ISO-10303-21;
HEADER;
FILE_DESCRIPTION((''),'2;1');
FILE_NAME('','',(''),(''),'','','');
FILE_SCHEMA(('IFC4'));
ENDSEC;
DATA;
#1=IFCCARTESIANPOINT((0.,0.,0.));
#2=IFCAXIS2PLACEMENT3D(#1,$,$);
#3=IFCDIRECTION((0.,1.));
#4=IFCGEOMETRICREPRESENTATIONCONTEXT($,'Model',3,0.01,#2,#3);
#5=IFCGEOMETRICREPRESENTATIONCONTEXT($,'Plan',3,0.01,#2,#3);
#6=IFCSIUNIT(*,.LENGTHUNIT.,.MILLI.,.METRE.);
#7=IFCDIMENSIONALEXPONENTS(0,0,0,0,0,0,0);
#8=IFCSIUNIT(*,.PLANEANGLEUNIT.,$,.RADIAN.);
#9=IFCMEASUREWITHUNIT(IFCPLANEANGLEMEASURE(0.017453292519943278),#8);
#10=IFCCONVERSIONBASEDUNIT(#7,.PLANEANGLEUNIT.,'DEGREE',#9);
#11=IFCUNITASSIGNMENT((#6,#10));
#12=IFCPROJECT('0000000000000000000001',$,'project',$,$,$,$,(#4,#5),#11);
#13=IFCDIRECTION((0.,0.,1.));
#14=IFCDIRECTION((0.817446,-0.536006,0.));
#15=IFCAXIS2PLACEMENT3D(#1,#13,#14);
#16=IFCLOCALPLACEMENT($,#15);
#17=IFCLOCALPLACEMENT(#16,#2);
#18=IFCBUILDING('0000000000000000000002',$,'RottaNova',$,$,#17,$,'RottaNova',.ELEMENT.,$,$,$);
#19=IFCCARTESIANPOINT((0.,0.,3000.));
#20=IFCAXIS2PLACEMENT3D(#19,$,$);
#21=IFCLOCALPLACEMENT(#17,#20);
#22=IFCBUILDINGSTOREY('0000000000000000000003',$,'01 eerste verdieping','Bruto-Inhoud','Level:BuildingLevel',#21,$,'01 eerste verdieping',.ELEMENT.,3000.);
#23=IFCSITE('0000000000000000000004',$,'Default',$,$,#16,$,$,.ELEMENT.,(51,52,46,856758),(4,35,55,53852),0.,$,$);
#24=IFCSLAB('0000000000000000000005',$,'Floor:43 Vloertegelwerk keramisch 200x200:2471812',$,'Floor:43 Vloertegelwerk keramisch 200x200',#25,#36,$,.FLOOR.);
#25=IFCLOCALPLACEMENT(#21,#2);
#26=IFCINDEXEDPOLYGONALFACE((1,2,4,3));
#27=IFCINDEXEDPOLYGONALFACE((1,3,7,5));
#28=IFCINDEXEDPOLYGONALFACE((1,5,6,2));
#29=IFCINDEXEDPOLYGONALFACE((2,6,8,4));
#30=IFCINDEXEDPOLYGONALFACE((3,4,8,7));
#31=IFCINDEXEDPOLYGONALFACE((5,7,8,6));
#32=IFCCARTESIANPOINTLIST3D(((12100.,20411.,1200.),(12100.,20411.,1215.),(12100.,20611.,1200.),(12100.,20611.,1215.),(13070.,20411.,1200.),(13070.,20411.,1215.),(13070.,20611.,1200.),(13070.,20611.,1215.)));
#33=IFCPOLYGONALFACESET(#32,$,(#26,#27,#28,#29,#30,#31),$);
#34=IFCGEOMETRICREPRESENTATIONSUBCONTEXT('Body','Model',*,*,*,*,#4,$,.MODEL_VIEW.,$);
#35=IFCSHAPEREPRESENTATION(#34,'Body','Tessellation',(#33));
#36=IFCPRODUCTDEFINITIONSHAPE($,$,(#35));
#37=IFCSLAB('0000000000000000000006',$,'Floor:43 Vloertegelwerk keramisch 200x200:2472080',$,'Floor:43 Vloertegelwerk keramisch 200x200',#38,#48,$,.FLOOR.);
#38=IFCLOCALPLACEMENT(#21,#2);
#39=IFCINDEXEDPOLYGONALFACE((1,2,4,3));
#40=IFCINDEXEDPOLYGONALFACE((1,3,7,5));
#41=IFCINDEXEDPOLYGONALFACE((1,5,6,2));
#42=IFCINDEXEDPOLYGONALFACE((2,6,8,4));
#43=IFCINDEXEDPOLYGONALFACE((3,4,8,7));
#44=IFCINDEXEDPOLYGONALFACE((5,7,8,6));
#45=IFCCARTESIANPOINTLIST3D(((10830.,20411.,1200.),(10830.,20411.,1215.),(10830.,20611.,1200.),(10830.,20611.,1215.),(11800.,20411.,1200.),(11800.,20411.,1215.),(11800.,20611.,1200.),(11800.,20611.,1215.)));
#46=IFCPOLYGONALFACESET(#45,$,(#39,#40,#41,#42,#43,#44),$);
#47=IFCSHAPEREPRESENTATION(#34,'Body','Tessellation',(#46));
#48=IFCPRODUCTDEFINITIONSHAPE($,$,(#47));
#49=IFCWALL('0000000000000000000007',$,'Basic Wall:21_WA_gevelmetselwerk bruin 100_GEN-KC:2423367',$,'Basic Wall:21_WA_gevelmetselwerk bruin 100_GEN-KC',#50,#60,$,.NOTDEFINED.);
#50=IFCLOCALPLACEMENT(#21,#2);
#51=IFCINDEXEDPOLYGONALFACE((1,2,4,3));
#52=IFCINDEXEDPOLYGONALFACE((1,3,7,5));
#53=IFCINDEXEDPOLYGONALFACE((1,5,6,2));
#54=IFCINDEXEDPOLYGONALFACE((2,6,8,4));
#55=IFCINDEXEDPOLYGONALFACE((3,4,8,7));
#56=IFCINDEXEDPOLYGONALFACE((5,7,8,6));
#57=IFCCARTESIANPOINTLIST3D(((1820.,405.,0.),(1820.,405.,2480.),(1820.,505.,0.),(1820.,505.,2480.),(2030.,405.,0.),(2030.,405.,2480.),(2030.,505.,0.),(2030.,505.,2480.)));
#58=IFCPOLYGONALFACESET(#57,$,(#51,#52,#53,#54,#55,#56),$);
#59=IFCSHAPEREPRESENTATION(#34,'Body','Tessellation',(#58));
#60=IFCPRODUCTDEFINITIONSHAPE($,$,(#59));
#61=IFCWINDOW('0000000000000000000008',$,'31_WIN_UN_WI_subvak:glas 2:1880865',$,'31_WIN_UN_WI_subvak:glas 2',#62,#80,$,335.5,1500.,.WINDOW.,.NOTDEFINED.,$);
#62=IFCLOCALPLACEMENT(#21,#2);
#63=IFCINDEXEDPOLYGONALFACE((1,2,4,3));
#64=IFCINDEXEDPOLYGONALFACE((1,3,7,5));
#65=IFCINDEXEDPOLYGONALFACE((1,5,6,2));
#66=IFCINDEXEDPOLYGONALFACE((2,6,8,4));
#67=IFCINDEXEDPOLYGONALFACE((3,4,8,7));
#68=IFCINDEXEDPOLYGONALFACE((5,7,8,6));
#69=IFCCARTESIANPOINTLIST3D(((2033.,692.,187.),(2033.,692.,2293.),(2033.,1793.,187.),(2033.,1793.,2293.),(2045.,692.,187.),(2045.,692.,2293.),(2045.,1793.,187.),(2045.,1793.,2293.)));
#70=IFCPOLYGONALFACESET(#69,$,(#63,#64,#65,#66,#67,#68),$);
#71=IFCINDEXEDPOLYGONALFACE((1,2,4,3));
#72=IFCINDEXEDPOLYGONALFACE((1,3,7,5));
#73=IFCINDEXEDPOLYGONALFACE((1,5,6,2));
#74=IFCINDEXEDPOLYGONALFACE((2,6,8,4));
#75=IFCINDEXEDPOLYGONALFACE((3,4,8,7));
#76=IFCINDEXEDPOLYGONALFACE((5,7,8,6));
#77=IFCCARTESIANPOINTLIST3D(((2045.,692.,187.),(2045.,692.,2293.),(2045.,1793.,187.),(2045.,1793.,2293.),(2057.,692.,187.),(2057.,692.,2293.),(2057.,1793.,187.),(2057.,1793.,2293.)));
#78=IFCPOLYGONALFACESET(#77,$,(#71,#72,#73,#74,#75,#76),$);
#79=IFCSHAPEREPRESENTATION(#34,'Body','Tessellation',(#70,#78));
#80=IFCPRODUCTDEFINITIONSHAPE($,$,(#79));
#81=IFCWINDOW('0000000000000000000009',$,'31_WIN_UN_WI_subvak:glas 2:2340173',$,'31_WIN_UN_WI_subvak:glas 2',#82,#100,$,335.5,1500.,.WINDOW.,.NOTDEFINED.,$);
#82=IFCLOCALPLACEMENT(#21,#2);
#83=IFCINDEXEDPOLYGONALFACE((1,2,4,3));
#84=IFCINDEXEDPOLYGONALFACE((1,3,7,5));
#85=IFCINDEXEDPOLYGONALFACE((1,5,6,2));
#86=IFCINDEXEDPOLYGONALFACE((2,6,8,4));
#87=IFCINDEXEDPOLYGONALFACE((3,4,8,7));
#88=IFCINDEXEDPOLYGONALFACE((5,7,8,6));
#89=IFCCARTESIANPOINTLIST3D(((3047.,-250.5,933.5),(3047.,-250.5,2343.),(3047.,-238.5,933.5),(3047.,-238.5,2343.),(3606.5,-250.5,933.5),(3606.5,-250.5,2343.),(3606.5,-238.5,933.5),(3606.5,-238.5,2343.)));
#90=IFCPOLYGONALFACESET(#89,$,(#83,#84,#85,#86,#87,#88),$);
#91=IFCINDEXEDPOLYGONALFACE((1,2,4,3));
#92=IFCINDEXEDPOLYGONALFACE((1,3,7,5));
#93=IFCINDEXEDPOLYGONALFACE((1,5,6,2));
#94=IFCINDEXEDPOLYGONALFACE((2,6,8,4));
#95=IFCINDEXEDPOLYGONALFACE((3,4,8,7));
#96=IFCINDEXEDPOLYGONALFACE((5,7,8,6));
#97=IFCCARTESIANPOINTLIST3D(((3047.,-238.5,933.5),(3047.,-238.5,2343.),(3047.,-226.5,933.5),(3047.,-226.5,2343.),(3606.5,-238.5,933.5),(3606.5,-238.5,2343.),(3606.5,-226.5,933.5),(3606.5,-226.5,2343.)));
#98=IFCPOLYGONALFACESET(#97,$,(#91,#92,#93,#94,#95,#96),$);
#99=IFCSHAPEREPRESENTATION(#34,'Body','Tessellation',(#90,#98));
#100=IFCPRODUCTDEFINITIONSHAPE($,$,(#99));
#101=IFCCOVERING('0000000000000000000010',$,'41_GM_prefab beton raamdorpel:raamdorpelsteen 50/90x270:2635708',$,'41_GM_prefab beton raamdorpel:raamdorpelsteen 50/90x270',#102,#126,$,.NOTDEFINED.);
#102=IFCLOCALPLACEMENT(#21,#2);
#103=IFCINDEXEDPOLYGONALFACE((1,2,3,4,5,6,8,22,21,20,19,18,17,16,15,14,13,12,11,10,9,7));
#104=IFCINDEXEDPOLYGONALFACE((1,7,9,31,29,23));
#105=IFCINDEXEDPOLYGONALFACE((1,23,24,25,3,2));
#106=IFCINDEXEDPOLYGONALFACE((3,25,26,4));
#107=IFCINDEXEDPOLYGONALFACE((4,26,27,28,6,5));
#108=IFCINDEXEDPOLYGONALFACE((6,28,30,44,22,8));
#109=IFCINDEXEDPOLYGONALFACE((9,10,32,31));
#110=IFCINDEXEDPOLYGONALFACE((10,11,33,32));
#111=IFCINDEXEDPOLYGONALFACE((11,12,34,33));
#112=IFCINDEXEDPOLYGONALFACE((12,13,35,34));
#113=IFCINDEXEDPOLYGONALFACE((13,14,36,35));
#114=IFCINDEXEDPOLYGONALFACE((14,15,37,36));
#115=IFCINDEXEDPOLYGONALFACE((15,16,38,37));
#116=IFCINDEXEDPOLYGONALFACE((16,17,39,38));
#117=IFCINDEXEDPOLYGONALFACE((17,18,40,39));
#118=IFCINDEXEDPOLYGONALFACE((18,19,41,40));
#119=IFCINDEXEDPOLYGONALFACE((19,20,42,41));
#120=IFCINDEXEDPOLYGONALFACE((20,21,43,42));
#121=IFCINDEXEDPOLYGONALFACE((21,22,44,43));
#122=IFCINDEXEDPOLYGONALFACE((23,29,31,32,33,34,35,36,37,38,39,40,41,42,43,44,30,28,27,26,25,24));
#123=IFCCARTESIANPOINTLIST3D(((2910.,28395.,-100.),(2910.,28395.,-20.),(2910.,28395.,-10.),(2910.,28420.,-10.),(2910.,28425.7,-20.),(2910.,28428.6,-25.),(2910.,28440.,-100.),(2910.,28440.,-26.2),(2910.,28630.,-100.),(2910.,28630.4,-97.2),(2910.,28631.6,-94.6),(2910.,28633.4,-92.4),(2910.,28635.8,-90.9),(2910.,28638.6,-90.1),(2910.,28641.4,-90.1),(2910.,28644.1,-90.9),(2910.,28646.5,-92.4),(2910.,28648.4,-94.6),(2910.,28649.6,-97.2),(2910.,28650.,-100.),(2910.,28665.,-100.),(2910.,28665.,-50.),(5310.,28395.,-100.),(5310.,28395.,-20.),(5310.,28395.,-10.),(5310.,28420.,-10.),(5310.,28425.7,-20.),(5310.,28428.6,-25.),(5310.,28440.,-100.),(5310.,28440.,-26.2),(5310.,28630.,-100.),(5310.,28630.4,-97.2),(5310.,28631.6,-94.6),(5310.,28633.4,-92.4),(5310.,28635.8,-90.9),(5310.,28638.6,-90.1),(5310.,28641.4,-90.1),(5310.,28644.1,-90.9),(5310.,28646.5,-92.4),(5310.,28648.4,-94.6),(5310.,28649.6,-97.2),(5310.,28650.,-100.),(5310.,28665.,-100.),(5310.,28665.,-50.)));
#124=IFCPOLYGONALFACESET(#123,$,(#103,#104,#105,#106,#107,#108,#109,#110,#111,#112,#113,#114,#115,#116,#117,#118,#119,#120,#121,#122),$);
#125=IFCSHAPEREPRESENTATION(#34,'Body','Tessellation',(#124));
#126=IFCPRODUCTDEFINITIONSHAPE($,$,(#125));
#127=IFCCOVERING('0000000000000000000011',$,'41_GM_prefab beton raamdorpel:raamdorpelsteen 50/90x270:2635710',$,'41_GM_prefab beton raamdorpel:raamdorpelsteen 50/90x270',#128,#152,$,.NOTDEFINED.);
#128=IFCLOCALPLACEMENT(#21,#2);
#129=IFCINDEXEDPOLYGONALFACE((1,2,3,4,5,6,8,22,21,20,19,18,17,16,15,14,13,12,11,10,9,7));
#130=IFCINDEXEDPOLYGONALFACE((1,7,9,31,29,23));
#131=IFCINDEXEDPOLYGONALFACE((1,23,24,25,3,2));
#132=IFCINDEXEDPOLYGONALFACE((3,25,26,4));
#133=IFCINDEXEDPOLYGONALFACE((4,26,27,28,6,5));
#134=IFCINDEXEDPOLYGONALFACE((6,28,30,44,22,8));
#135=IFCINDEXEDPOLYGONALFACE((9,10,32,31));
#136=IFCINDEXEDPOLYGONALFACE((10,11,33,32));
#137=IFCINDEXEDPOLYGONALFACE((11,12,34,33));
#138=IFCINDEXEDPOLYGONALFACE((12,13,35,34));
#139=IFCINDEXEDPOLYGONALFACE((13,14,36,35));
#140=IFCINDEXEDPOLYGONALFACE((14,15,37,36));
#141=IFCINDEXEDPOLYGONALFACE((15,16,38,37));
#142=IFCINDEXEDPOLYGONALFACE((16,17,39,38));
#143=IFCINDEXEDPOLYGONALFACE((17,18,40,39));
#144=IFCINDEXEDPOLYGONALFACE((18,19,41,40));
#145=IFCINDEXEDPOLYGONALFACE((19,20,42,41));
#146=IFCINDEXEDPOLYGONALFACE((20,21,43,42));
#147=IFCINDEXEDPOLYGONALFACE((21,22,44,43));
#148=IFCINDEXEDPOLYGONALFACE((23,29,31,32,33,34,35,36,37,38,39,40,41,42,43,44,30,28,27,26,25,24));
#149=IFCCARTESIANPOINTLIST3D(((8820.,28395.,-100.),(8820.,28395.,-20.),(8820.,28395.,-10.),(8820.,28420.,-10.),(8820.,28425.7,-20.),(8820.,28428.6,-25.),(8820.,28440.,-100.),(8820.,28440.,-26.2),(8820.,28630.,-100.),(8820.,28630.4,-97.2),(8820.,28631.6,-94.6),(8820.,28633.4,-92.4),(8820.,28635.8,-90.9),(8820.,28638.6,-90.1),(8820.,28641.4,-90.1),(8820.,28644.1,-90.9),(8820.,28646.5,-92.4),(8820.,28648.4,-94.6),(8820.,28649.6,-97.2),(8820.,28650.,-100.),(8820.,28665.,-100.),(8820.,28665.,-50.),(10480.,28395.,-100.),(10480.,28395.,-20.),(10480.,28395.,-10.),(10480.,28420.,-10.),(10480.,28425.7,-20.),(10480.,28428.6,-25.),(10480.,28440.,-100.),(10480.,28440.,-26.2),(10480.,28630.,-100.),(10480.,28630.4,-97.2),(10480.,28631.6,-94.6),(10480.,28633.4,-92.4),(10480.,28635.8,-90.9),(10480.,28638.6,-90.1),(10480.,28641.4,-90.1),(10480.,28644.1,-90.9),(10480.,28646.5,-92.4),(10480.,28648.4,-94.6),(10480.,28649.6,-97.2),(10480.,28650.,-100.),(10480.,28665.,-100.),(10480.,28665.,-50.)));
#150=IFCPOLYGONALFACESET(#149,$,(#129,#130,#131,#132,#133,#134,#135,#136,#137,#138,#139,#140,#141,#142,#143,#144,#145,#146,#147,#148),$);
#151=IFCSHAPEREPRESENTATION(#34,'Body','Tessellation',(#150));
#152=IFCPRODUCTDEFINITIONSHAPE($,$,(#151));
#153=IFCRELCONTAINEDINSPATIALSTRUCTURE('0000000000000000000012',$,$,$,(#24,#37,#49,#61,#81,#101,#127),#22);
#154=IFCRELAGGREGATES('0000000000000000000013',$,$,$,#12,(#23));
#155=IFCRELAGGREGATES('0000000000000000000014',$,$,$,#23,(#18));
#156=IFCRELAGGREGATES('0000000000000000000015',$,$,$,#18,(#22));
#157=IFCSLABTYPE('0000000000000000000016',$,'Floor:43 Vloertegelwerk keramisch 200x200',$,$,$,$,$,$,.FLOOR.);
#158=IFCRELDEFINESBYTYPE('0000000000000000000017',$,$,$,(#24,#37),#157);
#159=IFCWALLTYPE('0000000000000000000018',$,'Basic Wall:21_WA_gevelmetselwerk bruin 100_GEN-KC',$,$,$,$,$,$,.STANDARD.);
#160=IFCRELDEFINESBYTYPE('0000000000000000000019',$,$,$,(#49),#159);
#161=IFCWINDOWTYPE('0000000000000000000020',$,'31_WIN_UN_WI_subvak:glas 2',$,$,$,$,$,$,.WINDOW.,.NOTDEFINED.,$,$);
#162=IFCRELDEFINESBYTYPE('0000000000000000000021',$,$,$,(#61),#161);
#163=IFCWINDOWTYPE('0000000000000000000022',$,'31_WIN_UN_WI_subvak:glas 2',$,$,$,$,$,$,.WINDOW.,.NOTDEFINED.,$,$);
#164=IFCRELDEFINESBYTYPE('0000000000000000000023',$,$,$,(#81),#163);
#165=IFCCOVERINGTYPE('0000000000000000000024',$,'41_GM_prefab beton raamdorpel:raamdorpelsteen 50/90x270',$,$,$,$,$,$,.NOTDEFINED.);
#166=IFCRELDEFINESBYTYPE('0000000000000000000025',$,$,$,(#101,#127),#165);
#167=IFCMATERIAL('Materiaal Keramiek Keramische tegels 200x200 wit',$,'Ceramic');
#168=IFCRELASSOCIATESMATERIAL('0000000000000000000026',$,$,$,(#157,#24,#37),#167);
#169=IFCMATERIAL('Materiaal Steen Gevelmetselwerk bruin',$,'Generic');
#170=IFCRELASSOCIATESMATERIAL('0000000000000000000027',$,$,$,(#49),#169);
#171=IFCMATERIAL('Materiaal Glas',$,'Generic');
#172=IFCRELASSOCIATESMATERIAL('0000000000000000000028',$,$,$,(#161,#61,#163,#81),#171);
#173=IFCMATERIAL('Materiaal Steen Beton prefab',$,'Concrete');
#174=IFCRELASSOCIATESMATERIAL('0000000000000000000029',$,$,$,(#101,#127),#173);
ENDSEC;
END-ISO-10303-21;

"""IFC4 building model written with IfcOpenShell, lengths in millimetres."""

from ifc_helpers import new_model, entity, si_unit, converted_unit, direction, frame, origin, place, context, subcontext, project, spatial, line, arc, indexed_curve, outline, extrude, source, transform, mapped, material, type_object, type_shapes, element, save


model = new_model("IFC4")

# Units and contexts
model_context = context("Model", 3, precision=0.01, world=origin(), true_north=direction((0.0, 1.0)))
plan_context = context("Plan", 3, precision=0.01, world=origin(), true_north=direction((0.0, 1.0)))
body_context = subcontext(model_context, "Body", "Model", "MODEL_VIEW")
ifc_project = project(units=[si_unit("LENGTHUNIT", "METRE", prefix="MILLI"), converted_unit("PLANEANGLEUNIT", "DEGREE", entity("IfcPlaneAngleMeasure", 0.017453292519943278), si_unit("PLANEANGLEUNIT", "RADIAN"), dimensions=[0, 0, 0, 0, 0, 0, 0])], contexts=[model_context, plan_context])

# Site, building, storey
site_placement = place(None, frame((0.0, 0.0, 0.0), z_axis=(0.0, 0.0, 1.0), x_axis=(0.817446, -0.536006, 0.0)))
site = spatial("IfcSite", under=ifc_project, at=site_placement, Name="Default", CompositionType="ELEMENT", RefLatitude=(51, 52, 46, 856758), RefLongitude=(4, 35, 55, 53852), RefElevation=0.0)
building_placement = place(site_placement, origin())
building = spatial("IfcBuilding", under=site, at=building_placement, Name="RottaNova", LongName="RottaNova", CompositionType="ELEMENT")
storey_placement = place(building_placement, frame((0.0, 0.0, 3000.0)))
storey = spatial("IfcBuildingStorey", under=building, at=storey_placement, Name="01 eerste verdieping", Description="Bruto-Inhoud", ObjectType="Level:BuildingLevel", LongName="01 eerste verdieping", CompositionType="ELEMENT", Elevation=3000.0)

# Slabs
ifc_material_1 = material(Name="Materiaal Keramiek Keramische tegels 200x200 wit", Category="Ceramic")
slab_type = type_object("IfcSlabType", Name="Floor:43 Vloertegelwerk keramisch 200x200", PredefinedType="FLOOR", material=ifc_material_1)
slab_1_placement = place(storey_placement, origin())
element("IfcSlab", 1, at=slab_1_placement, inside=storey, type_object=slab_type, material=ifc_material_1, Name="Floor:43 Vloertegelwerk keramisch 200x200:2471812", ObjectType="Floor:43 Vloertegelwerk keramisch 200x200", PredefinedType="FLOOR", context=body_context, shape_type="SweptSolid", body=[
    extrude(outline(indexed_curve([(-100.0, -485.0), (100.0, -485.0), (100.0, 485.0), (-100.0, 485.0), (-100.0, -485.0)], self_intersect=False)), frame((12585.0, 20511.0, 1215.0), z_axis=(0.0, 0.0, -1.0), x_axis=(0.0, 1.0, 0.0)), (0.0, 0.0, 1.0), 15.0),
])
slab_2_placement = place(storey_placement, origin())
element("IfcSlab", 2, at=slab_2_placement, inside=storey, type_object=slab_type, material=ifc_material_1, Name="Floor:43 Vloertegelwerk keramisch 200x200:2472080", ObjectType="Floor:43 Vloertegelwerk keramisch 200x200", PredefinedType="FLOOR", context=body_context, shape_type="SweptSolid", body=[
    extrude(outline(indexed_curve([(-100.0, -485.0), (100.0, -485.0), (100.0, 485.0), (-100.0, 485.0), (-100.0, -485.0)], self_intersect=False)), frame((11315.0, 20511.0, 1215.0), z_axis=(0.0, 0.0, -1.0), x_axis=(0.0, 1.0, 0.0)), (0.0, 0.0, 1.0), 15.0),
])

# Wall
ifc_material_2 = material(Name="Materiaal Steen Gevelmetselwerk bruin", Category="Generic")
wall_type = type_object("IfcWallType", Name="Basic Wall:21_WA_gevelmetselwerk bruin 100_GEN-KC", PredefinedType="STANDARD")
wall_placement = place(storey_placement, frame((2030.0, 455.0, 0.0), z_axis=(0.0, 0.0, 1.0), x_axis=(-1.0, 0.0, 0.0)))
element("IfcWall", 3, at=wall_placement, inside=storey, type_object=wall_type, material=ifc_material_2, Name="Basic Wall:21_WA_gevelmetselwerk bruin 100_GEN-KC:2423367", ObjectType="Basic Wall:21_WA_gevelmetselwerk bruin 100_GEN-KC", PredefinedType="NOTDEFINED", context=body_context, shape_type="SweptSolid", body=[
    extrude(outline(indexed_curve([(210.0, 50.0), (0.0, 50.0), (0.0, -50.0), (210.0, -50.0), (210.0, 50.0)], self_intersect=False)), origin(), (0.0, 0.0, 1.0), 2480.0),
])

# Windows
ifc_material_3 = material(Name="Materiaal Glas", Category="Generic")
window_type_1 = type_object("IfcWindowType", Name="31_WIN_UN_WI_subvak:glas 2", PartitioningType="NOTDEFINED", PredefinedType="WINDOW", material=ifc_material_3)
shared_shape_1 = source(origin(), body_context, "Body", "SweptSolid", [
    extrude(outline(indexed_curve([(-6.0, -550.5), (6.0, -550.5), (6.0, 550.5), (-6.0, 550.5), (-6.0, -550.5)], self_intersect=False)), frame((0.0, 6.0, 0.0), z_axis=(0.0, 0.0, 1.0), x_axis=(0.0, -1.0, 0.0)), (0.0, 0.0, 1.0), 2106.0),
    extrude(outline(indexed_curve([(-6.0, -550.5), (6.0, -550.5), (6.0, 550.5), (-6.0, 550.5), (-6.0, -550.5)], self_intersect=False)), frame((0.0, -6.0, 0.0), z_axis=(0.0, 0.0, 1.0), x_axis=(0.0, -1.0, 0.0)), (0.0, 0.0, 1.0), 2106.0),
])
type_shapes(window_type_1, [shared_shape_1])
window_1_placement = place(storey_placement, frame((2045.0, 1242.5, 187.0), z_axis=(0.0, 0.0, 1.0), x_axis=(0.0, 1.0, 0.0)))
element("IfcWindow", 4, at=window_1_placement, inside=storey, type_object=window_type_1, material=ifc_material_3, Name="31_WIN_UN_WI_subvak:glas 2:1880865", ObjectType="31_WIN_UN_WI_subvak:glas 2", OverallHeight=335.5, OverallWidth=1500.0, PartitioningType="NOTDEFINED", PredefinedType="WINDOW", context=body_context, shape_type="MappedRepresentation", body=[
    mapped(shared_shape_1, transform((0.0, 0.0, 0.0), scale=1.0)),
])
window_type_2 = type_object("IfcWindowType", Name="31_WIN_UN_WI_subvak:glas 2", PartitioningType="NOTDEFINED", PredefinedType="WINDOW", material=ifc_material_3)
shared_shape_2 = source(origin(), body_context, "Body", "SweptSolid", [
    extrude(outline(indexed_curve([(-6.0, -279.8), (6.0, -279.8), (6.0, 279.8), (-6.0, 279.8), (-6.0, -279.8)], self_intersect=False)), frame((0.0, 6.0, 0.0), z_axis=(0.0, 0.0, 1.0), x_axis=(0.0, -1.0, 0.0)), (0.0, 0.0, 1.0), 1409.5),
    extrude(outline(indexed_curve([(-6.0, -279.8), (6.0, -279.8), (6.0, 279.8), (-6.0, 279.8), (-6.0, -279.8)], self_intersect=False)), frame((0.0, -6.0, 0.0), z_axis=(0.0, 0.0, 1.0), x_axis=(0.0, -1.0, 0.0)), (0.0, 0.0, 1.0), 1409.5),
])
type_shapes(window_type_2, [shared_shape_2])
window_2_placement = place(storey_placement, frame((3326.7, -238.5, 933.5), z_axis=(0.0, 0.0, 1.0), x_axis=(-1.0, 0.0, 0.0)))
element("IfcWindow", 5, at=window_2_placement, inside=storey, type_object=window_type_2, material=ifc_material_3, Name="31_WIN_UN_WI_subvak:glas 2:2340173", ObjectType="31_WIN_UN_WI_subvak:glas 2", OverallHeight=335.5, OverallWidth=1500.0, PartitioningType="NOTDEFINED", PredefinedType="WINDOW", context=body_context, shape_type="MappedRepresentation", body=[
    mapped(shared_shape_2, transform((0.0, 0.0, 0.0), scale=1.0)),
])

# Coverings
ifc_material_4 = material(Name="Materiaal Steen Beton prefab", Category="Concrete")
covering_type_1 = type_object("IfcCoveringType", Name="41_GM_prefab beton raamdorpel:raamdorpelsteen 50/90x270", PredefinedType="NOTDEFINED")
covering_1_placement = place(storey_placement, origin())
element("IfcCovering", 6, at=covering_1_placement, inside=storey, type_object=covering_type_1, material=ifc_material_4, Name="41_GM_prefab beton raamdorpel:raamdorpelsteen 50/90x270:2635708", ObjectType="41_GM_prefab beton raamdorpel:raamdorpelsteen 50/90x270", PredefinedType="NOTDEFINED", context=body_context, shape_type="SweptSolid", body=[
    extrude(outline(indexed_curve([(75.8, -45.1), (100.8, -45.1), (100.8, -35.1), (100.8, 44.9), (55.8, 44.9), (-134.2, 44.9), (-144.2, 34.9), (-154.2, 44.9), (-169.2, 44.9), (-169.2, -5.1), (55.8, -28.9), (67.1, -30.1), (70.0, -35.1)], segments=[line(1, 2, 3, 4, 5, 6), arc(6, 7, 8), line(8, 9, 10, 11, 12, 13, 1)], self_intersect=False)), frame((2910.0, 28495.8, -55.1), z_axis=(1.0, 0.0, 0.0), x_axis=(0.0, -1.0, 0.0)), (0.0, 0.0, 1.0), 2400.0),
])
covering_2_placement = place(storey_placement, origin())
element("IfcCovering", 7, at=covering_2_placement, inside=storey, type_object=covering_type_1, material=ifc_material_4, Name="41_GM_prefab beton raamdorpel:raamdorpelsteen 50/90x270:2635710", ObjectType="41_GM_prefab beton raamdorpel:raamdorpelsteen 50/90x270", PredefinedType="NOTDEFINED", context=body_context, shape_type="SweptSolid", body=[
    extrude(outline(indexed_curve([(75.8, -45.1), (100.8, -45.1), (100.8, -35.1), (100.8, 44.9), (55.8, 44.9), (-134.2, 44.9), (-144.2, 34.9), (-154.2, 44.9), (-169.2, 44.9), (-169.2, -5.1), (55.8, -28.9), (67.1, -30.1), (70.0, -35.1)], segments=[line(1, 2, 3, 4, 5, 6), arc(6, 7, 8), line(8, 9, 10, 11, 12, 13, 1)], self_intersect=False)), frame((8820.0, 28495.8, -55.1), z_axis=(1.0, 0.0, 0.0), x_axis=(0.0, -1.0, 0.0)), (0.0, 0.0, 1.0), 1660.0),
])

save(model, "model.ifc")
